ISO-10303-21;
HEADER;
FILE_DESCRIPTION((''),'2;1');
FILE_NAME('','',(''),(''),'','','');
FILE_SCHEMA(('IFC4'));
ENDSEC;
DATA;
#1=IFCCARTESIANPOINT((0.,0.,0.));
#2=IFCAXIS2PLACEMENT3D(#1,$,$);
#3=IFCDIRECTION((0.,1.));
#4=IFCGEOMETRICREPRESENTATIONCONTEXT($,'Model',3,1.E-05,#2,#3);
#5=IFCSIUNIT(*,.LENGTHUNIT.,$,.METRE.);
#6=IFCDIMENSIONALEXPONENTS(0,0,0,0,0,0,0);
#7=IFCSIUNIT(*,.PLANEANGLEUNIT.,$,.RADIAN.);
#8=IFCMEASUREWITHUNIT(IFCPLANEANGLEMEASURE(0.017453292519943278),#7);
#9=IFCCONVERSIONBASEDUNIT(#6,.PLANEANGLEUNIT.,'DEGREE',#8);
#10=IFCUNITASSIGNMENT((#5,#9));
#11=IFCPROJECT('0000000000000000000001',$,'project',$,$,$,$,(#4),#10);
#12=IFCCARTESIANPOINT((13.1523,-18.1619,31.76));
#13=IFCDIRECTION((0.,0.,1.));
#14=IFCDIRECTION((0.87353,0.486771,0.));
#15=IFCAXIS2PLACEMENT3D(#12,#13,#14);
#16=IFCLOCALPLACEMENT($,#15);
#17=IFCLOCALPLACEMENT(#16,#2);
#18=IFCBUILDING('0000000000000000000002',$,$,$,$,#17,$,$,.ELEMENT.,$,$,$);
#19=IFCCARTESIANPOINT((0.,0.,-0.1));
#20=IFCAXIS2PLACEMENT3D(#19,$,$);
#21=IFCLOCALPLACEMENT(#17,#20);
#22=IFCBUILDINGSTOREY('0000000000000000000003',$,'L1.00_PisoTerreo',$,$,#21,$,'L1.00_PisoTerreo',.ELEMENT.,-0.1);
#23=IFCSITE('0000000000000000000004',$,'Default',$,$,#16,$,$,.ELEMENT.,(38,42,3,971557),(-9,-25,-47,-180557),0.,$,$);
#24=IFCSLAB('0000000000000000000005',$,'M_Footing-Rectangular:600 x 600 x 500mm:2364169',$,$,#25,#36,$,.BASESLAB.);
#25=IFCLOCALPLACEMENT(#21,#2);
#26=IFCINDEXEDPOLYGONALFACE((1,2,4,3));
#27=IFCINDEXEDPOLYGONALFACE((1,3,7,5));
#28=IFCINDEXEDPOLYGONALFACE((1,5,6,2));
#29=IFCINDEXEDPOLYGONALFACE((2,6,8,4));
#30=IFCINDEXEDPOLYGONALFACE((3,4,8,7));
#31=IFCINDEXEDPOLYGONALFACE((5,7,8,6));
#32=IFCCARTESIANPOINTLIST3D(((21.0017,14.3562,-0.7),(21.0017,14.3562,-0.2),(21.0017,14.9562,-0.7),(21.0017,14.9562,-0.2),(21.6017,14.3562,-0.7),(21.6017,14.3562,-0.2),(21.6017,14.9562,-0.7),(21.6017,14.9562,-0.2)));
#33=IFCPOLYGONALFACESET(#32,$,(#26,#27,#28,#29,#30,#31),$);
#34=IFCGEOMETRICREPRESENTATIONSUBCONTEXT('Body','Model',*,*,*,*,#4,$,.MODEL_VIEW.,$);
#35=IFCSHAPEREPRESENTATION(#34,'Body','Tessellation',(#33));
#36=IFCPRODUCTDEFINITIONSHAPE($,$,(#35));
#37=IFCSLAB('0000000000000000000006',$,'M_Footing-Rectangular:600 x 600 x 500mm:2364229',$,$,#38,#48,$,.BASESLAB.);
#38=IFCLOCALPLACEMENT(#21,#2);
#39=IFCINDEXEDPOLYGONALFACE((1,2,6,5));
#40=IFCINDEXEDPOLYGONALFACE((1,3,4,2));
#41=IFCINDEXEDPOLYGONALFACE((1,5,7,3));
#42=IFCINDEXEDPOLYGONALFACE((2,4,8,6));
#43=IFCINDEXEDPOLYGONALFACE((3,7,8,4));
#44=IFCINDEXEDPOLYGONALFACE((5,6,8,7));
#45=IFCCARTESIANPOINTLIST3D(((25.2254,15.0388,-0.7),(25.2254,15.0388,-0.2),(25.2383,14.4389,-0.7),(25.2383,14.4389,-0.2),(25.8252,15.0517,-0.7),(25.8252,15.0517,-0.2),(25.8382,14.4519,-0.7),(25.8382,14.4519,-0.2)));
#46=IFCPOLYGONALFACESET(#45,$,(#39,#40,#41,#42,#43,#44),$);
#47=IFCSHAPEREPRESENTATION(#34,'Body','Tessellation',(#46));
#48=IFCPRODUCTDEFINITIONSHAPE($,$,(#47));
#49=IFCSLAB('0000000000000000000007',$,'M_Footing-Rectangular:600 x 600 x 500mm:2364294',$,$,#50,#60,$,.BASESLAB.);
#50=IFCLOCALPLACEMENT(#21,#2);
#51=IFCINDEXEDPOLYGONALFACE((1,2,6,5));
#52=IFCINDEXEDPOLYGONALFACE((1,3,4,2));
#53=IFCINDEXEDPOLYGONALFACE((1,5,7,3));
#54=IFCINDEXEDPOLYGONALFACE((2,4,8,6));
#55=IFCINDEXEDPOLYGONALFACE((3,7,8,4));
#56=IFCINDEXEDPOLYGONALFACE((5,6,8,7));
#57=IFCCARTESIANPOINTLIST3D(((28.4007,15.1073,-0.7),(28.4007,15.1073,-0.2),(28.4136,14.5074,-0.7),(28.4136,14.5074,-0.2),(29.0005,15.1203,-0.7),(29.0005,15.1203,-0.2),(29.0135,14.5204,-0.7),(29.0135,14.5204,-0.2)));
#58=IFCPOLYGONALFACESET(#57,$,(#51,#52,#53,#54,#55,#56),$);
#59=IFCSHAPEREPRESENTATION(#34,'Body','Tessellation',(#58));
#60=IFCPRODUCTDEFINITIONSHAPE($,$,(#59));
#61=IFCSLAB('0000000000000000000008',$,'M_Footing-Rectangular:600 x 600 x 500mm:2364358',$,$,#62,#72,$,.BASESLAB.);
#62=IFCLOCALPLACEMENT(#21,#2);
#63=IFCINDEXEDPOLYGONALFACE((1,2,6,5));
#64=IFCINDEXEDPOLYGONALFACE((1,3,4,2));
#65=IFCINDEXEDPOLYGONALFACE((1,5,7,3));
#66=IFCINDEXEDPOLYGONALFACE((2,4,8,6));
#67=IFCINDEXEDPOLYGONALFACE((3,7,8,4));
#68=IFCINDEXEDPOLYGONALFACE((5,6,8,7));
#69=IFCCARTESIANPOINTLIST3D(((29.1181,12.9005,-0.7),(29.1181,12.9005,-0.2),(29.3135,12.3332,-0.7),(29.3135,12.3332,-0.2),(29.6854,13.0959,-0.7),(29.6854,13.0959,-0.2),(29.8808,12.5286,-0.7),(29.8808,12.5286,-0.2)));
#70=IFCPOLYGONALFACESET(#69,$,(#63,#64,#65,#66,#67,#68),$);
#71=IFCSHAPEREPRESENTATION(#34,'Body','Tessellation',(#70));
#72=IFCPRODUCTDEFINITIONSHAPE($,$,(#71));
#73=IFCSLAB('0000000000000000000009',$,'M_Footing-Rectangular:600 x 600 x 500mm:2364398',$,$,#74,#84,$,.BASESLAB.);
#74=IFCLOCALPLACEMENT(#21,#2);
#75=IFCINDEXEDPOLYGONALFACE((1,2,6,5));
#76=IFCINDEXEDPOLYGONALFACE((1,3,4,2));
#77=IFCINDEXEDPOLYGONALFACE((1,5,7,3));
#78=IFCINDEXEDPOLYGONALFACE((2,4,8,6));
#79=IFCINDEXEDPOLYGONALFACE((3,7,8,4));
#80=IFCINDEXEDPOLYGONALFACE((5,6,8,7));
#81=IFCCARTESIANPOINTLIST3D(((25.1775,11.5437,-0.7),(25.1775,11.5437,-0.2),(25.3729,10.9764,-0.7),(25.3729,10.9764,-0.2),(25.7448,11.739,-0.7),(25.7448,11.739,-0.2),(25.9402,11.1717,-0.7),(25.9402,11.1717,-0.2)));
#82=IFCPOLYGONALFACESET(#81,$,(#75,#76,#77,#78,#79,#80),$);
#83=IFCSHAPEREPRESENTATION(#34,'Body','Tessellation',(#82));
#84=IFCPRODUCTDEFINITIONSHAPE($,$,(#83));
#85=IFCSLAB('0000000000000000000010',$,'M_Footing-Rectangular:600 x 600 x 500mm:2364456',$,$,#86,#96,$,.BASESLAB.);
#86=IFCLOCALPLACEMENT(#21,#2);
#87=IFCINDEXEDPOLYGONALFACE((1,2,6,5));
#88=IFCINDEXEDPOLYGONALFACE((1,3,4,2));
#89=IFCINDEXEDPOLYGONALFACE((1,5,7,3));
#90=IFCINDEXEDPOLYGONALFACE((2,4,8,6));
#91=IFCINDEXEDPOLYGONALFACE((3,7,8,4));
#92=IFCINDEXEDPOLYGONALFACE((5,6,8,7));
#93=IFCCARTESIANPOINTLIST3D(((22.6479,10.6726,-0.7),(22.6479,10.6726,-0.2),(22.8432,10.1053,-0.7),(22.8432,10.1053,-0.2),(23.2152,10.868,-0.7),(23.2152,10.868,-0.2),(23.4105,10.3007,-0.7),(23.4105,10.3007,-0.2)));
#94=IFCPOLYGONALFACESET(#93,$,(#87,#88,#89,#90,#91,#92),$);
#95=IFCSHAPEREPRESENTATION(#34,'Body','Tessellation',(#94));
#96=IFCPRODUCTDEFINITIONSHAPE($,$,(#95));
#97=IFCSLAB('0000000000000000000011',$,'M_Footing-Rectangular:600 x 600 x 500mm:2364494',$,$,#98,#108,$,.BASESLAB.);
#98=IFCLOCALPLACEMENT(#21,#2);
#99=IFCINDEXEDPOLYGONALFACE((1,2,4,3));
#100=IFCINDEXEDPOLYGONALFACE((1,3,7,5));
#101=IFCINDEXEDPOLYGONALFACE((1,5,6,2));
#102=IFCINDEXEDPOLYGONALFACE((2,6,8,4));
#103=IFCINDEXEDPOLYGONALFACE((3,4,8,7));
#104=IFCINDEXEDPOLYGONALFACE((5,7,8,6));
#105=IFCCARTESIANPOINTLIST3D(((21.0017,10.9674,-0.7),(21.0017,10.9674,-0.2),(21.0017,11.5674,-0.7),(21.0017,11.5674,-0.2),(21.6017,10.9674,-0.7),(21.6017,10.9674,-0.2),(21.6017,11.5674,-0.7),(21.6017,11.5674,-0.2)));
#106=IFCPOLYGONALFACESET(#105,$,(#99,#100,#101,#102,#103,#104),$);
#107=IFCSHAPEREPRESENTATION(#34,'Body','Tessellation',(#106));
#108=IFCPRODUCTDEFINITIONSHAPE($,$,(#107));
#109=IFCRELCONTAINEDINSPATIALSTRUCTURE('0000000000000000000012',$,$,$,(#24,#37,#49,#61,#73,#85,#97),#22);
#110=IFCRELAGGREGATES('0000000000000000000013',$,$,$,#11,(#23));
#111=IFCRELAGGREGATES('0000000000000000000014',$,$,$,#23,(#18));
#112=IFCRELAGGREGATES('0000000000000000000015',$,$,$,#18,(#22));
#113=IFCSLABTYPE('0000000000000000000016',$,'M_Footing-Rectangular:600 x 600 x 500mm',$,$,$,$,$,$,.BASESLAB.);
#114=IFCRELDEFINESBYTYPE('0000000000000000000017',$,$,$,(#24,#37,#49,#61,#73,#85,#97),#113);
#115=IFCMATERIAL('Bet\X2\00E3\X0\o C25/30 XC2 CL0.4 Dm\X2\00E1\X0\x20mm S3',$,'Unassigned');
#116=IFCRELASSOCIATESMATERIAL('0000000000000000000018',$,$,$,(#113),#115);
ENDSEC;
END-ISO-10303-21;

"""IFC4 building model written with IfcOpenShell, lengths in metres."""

from ifc_helpers import new_model, entity, si_unit, converted_unit, direction, frame, origin, place, context, subcontext, project, spatial, indexed_curve, outline, extrude, material, type_object, element, save


model = new_model("IFC4")

# Units and contexts
model_context = context("Model", 3, precision=1e-05, world=origin(), true_north=direction((0.0, 1.0)))
body_context = subcontext(model_context, "Body", "Model", "MODEL_VIEW")
ifc_project = project(units=[si_unit("LENGTHUNIT", "METRE"), converted_unit("PLANEANGLEUNIT", "DEGREE", entity("IfcPlaneAngleMeasure", 0.017453292519943278), si_unit("PLANEANGLEUNIT", "RADIAN"), dimensions=[0, 0, 0, 0, 0, 0, 0])], contexts=[model_context])

# Site, building, storey
site_placement = place(None, frame((13.1523, -18.1619, 31.76), z_axis=(0.0, 0.0, 1.0), x_axis=(0.87353, 0.486771, 0.0)))
site = spatial("IfcSite", under=ifc_project, at=site_placement, Name="Default", CompositionType="ELEMENT", RefLatitude=(38, 42, 3, 971557), RefLongitude=(-9, -25, -47, -180557), RefElevation=0.0)
building_placement = place(site_placement, origin())
building = spatial("IfcBuilding", under=site, at=building_placement, CompositionType="ELEMENT")
storey_placement = place(building_placement, frame((0.0, 0.0, -0.1)))
storey = spatial("IfcBuildingStorey", under=building, at=storey_placement, Name="L1.00_PisoTerreo", LongName="L1.00_PisoTerreo", CompositionType="ELEMENT", Elevation=-0.1)

# Slabs
ifc_material_1 = material(Name="Betão C25/30 XC2 CL0.4 Dmáx20mm S3", Category="Unassigned")
slab_type = type_object("IfcSlabType", Name="M_Footing-Rectangular:600 x 600 x 500mm", PredefinedType="BASESLAB", material=ifc_material_1)
slab_1_placement = place(storey_placement, origin())
element("IfcSlab", 1, at=slab_1_placement, inside=storey, type_object=slab_type, Name="M_Footing-Rectangular:600 x 600 x 500mm:2364169", PredefinedType="BASESLAB", context=body_context, shape_type="SweptSolid", body=[
    extrude(outline(indexed_curve([(-0.3, -0.3), (0.3, -0.3), (0.3, 0.3), (-0.3, 0.3), (-0.3, -0.3)], self_intersect=False)), frame((21.3017, 14.6562, -0.7), z_axis=(0.0, 0.0, 1.0), x_axis=(-1.0, 0.0, 0.0)), (0.0, 0.0, 1.0), 0.5),
])
slab_2_placement = place(storey_placement, origin())
element("IfcSlab", 2, at=slab_2_placement, inside=storey, type_object=slab_type, Name="M_Footing-Rectangular:600 x 600 x 500mm:2364229", PredefinedType="BASESLAB", context=body_context, shape_type="SweptSolid", body=[
    extrude(outline(indexed_curve([(-0.3, -0.3), (0.3, -0.3), (0.3, 0.3), (-0.3, 0.3), (-0.3, -0.3)], self_intersect=False)), frame((25.5318, 14.7453, -0.7), z_axis=(0.0, 0.0, 1.0), x_axis=(-0.999767, -0.021581, 0.0)), (0.0, 0.0, 1.0), 0.5),
])
slab_3_placement = place(storey_placement, origin())
element("IfcSlab", 3, at=slab_3_placement, inside=storey, type_object=slab_type, Name="M_Footing-Rectangular:600 x 600 x 500mm:2364294", PredefinedType="BASESLAB", context=body_context, shape_type="SweptSolid", body=[
    extrude(outline(indexed_curve([(-0.3, -0.3), (0.3, -0.3), (0.3, 0.3), (-0.3, 0.3), (-0.3, -0.3)], self_intersect=False)), frame((28.7071, 14.8139, -0.7), z_axis=(0.0, 0.0, 1.0), x_axis=(-0.999767, -0.021581, 0.0)), (0.0, 0.0, 1.0), 0.5),
])
slab_4_placement = place(storey_placement, origin())
element("IfcSlab", 4, at=slab_4_placement, inside=storey, type_object=slab_type, Name="M_Footing-Rectangular:600 x 600 x 500mm:2364358", PredefinedType="BASESLAB", context=body_context, shape_type="SweptSolid", body=[
    extrude(outline(indexed_curve([(-0.3, -0.3), (0.3, -0.3), (0.3, 0.3), (-0.3, 0.3), (-0.3, -0.3)], self_intersect=False)), frame((29.4995, 12.7146, -0.7), z_axis=(0.0, 0.0, 1.0), x_axis=(-0.945519, -0.325568, 0.0)), (0.0, 0.0, 1.0), 0.5),
])
slab_5_placement = place(storey_placement, origin())
element("IfcSlab", 5, at=slab_5_placement, inside=storey, type_object=slab_type, Name="M_Footing-Rectangular:600 x 600 x 500mm:2364398", PredefinedType="BASESLAB", context=body_context, shape_type="SweptSolid", body=[
    extrude(outline(indexed_curve([(-0.3, -0.3), (0.3, -0.3), (0.3, 0.3), (-0.3, 0.3), (-0.3, -0.3)], self_intersect=False)), frame((25.5588, 11.3577, -0.7), z_axis=(0.0, 0.0, 1.0), x_axis=(-0.945519, -0.325568, 0.0)), (0.0, 0.0, 1.0), 0.5),
])
slab_6_placement = place(storey_placement, origin())
element("IfcSlab", 6, at=slab_6_placement, inside=storey, type_object=slab_type, Name="M_Footing-Rectangular:600 x 600 x 500mm:2364456", PredefinedType="BASESLAB", context=body_context, shape_type="SweptSolid", body=[
    extrude(outline(indexed_curve([(-0.3, -0.3), (0.3, -0.3), (0.3, 0.3), (-0.3, 0.3), (-0.3, -0.3)], self_intersect=False)), frame((23.0292, 10.4867, -0.7), z_axis=(0.0, 0.0, 1.0), x_axis=(-0.945519, -0.325568, 0.0)), (0.0, 0.0, 1.0), 0.5),
])
slab_7_placement = place(storey_placement, origin())
element("IfcSlab", 7, at=slab_7_placement, inside=storey, type_object=slab_type, Name="M_Footing-Rectangular:600 x 600 x 500mm:2364494", PredefinedType="BASESLAB", context=body_context, shape_type="SweptSolid", body=[
    extrude(outline(indexed_curve([(-0.3, -0.3), (0.3, -0.3), (0.3, 0.3), (-0.3, 0.3), (-0.3, -0.3)], self_intersect=False)), frame((21.3017, 11.2674, -0.7), z_axis=(0.0, 0.0, 1.0), x_axis=(-1.0, 0.0, 0.0)), (0.0, 0.0, 1.0), 0.5),
])

save(model, "model.ifc")
